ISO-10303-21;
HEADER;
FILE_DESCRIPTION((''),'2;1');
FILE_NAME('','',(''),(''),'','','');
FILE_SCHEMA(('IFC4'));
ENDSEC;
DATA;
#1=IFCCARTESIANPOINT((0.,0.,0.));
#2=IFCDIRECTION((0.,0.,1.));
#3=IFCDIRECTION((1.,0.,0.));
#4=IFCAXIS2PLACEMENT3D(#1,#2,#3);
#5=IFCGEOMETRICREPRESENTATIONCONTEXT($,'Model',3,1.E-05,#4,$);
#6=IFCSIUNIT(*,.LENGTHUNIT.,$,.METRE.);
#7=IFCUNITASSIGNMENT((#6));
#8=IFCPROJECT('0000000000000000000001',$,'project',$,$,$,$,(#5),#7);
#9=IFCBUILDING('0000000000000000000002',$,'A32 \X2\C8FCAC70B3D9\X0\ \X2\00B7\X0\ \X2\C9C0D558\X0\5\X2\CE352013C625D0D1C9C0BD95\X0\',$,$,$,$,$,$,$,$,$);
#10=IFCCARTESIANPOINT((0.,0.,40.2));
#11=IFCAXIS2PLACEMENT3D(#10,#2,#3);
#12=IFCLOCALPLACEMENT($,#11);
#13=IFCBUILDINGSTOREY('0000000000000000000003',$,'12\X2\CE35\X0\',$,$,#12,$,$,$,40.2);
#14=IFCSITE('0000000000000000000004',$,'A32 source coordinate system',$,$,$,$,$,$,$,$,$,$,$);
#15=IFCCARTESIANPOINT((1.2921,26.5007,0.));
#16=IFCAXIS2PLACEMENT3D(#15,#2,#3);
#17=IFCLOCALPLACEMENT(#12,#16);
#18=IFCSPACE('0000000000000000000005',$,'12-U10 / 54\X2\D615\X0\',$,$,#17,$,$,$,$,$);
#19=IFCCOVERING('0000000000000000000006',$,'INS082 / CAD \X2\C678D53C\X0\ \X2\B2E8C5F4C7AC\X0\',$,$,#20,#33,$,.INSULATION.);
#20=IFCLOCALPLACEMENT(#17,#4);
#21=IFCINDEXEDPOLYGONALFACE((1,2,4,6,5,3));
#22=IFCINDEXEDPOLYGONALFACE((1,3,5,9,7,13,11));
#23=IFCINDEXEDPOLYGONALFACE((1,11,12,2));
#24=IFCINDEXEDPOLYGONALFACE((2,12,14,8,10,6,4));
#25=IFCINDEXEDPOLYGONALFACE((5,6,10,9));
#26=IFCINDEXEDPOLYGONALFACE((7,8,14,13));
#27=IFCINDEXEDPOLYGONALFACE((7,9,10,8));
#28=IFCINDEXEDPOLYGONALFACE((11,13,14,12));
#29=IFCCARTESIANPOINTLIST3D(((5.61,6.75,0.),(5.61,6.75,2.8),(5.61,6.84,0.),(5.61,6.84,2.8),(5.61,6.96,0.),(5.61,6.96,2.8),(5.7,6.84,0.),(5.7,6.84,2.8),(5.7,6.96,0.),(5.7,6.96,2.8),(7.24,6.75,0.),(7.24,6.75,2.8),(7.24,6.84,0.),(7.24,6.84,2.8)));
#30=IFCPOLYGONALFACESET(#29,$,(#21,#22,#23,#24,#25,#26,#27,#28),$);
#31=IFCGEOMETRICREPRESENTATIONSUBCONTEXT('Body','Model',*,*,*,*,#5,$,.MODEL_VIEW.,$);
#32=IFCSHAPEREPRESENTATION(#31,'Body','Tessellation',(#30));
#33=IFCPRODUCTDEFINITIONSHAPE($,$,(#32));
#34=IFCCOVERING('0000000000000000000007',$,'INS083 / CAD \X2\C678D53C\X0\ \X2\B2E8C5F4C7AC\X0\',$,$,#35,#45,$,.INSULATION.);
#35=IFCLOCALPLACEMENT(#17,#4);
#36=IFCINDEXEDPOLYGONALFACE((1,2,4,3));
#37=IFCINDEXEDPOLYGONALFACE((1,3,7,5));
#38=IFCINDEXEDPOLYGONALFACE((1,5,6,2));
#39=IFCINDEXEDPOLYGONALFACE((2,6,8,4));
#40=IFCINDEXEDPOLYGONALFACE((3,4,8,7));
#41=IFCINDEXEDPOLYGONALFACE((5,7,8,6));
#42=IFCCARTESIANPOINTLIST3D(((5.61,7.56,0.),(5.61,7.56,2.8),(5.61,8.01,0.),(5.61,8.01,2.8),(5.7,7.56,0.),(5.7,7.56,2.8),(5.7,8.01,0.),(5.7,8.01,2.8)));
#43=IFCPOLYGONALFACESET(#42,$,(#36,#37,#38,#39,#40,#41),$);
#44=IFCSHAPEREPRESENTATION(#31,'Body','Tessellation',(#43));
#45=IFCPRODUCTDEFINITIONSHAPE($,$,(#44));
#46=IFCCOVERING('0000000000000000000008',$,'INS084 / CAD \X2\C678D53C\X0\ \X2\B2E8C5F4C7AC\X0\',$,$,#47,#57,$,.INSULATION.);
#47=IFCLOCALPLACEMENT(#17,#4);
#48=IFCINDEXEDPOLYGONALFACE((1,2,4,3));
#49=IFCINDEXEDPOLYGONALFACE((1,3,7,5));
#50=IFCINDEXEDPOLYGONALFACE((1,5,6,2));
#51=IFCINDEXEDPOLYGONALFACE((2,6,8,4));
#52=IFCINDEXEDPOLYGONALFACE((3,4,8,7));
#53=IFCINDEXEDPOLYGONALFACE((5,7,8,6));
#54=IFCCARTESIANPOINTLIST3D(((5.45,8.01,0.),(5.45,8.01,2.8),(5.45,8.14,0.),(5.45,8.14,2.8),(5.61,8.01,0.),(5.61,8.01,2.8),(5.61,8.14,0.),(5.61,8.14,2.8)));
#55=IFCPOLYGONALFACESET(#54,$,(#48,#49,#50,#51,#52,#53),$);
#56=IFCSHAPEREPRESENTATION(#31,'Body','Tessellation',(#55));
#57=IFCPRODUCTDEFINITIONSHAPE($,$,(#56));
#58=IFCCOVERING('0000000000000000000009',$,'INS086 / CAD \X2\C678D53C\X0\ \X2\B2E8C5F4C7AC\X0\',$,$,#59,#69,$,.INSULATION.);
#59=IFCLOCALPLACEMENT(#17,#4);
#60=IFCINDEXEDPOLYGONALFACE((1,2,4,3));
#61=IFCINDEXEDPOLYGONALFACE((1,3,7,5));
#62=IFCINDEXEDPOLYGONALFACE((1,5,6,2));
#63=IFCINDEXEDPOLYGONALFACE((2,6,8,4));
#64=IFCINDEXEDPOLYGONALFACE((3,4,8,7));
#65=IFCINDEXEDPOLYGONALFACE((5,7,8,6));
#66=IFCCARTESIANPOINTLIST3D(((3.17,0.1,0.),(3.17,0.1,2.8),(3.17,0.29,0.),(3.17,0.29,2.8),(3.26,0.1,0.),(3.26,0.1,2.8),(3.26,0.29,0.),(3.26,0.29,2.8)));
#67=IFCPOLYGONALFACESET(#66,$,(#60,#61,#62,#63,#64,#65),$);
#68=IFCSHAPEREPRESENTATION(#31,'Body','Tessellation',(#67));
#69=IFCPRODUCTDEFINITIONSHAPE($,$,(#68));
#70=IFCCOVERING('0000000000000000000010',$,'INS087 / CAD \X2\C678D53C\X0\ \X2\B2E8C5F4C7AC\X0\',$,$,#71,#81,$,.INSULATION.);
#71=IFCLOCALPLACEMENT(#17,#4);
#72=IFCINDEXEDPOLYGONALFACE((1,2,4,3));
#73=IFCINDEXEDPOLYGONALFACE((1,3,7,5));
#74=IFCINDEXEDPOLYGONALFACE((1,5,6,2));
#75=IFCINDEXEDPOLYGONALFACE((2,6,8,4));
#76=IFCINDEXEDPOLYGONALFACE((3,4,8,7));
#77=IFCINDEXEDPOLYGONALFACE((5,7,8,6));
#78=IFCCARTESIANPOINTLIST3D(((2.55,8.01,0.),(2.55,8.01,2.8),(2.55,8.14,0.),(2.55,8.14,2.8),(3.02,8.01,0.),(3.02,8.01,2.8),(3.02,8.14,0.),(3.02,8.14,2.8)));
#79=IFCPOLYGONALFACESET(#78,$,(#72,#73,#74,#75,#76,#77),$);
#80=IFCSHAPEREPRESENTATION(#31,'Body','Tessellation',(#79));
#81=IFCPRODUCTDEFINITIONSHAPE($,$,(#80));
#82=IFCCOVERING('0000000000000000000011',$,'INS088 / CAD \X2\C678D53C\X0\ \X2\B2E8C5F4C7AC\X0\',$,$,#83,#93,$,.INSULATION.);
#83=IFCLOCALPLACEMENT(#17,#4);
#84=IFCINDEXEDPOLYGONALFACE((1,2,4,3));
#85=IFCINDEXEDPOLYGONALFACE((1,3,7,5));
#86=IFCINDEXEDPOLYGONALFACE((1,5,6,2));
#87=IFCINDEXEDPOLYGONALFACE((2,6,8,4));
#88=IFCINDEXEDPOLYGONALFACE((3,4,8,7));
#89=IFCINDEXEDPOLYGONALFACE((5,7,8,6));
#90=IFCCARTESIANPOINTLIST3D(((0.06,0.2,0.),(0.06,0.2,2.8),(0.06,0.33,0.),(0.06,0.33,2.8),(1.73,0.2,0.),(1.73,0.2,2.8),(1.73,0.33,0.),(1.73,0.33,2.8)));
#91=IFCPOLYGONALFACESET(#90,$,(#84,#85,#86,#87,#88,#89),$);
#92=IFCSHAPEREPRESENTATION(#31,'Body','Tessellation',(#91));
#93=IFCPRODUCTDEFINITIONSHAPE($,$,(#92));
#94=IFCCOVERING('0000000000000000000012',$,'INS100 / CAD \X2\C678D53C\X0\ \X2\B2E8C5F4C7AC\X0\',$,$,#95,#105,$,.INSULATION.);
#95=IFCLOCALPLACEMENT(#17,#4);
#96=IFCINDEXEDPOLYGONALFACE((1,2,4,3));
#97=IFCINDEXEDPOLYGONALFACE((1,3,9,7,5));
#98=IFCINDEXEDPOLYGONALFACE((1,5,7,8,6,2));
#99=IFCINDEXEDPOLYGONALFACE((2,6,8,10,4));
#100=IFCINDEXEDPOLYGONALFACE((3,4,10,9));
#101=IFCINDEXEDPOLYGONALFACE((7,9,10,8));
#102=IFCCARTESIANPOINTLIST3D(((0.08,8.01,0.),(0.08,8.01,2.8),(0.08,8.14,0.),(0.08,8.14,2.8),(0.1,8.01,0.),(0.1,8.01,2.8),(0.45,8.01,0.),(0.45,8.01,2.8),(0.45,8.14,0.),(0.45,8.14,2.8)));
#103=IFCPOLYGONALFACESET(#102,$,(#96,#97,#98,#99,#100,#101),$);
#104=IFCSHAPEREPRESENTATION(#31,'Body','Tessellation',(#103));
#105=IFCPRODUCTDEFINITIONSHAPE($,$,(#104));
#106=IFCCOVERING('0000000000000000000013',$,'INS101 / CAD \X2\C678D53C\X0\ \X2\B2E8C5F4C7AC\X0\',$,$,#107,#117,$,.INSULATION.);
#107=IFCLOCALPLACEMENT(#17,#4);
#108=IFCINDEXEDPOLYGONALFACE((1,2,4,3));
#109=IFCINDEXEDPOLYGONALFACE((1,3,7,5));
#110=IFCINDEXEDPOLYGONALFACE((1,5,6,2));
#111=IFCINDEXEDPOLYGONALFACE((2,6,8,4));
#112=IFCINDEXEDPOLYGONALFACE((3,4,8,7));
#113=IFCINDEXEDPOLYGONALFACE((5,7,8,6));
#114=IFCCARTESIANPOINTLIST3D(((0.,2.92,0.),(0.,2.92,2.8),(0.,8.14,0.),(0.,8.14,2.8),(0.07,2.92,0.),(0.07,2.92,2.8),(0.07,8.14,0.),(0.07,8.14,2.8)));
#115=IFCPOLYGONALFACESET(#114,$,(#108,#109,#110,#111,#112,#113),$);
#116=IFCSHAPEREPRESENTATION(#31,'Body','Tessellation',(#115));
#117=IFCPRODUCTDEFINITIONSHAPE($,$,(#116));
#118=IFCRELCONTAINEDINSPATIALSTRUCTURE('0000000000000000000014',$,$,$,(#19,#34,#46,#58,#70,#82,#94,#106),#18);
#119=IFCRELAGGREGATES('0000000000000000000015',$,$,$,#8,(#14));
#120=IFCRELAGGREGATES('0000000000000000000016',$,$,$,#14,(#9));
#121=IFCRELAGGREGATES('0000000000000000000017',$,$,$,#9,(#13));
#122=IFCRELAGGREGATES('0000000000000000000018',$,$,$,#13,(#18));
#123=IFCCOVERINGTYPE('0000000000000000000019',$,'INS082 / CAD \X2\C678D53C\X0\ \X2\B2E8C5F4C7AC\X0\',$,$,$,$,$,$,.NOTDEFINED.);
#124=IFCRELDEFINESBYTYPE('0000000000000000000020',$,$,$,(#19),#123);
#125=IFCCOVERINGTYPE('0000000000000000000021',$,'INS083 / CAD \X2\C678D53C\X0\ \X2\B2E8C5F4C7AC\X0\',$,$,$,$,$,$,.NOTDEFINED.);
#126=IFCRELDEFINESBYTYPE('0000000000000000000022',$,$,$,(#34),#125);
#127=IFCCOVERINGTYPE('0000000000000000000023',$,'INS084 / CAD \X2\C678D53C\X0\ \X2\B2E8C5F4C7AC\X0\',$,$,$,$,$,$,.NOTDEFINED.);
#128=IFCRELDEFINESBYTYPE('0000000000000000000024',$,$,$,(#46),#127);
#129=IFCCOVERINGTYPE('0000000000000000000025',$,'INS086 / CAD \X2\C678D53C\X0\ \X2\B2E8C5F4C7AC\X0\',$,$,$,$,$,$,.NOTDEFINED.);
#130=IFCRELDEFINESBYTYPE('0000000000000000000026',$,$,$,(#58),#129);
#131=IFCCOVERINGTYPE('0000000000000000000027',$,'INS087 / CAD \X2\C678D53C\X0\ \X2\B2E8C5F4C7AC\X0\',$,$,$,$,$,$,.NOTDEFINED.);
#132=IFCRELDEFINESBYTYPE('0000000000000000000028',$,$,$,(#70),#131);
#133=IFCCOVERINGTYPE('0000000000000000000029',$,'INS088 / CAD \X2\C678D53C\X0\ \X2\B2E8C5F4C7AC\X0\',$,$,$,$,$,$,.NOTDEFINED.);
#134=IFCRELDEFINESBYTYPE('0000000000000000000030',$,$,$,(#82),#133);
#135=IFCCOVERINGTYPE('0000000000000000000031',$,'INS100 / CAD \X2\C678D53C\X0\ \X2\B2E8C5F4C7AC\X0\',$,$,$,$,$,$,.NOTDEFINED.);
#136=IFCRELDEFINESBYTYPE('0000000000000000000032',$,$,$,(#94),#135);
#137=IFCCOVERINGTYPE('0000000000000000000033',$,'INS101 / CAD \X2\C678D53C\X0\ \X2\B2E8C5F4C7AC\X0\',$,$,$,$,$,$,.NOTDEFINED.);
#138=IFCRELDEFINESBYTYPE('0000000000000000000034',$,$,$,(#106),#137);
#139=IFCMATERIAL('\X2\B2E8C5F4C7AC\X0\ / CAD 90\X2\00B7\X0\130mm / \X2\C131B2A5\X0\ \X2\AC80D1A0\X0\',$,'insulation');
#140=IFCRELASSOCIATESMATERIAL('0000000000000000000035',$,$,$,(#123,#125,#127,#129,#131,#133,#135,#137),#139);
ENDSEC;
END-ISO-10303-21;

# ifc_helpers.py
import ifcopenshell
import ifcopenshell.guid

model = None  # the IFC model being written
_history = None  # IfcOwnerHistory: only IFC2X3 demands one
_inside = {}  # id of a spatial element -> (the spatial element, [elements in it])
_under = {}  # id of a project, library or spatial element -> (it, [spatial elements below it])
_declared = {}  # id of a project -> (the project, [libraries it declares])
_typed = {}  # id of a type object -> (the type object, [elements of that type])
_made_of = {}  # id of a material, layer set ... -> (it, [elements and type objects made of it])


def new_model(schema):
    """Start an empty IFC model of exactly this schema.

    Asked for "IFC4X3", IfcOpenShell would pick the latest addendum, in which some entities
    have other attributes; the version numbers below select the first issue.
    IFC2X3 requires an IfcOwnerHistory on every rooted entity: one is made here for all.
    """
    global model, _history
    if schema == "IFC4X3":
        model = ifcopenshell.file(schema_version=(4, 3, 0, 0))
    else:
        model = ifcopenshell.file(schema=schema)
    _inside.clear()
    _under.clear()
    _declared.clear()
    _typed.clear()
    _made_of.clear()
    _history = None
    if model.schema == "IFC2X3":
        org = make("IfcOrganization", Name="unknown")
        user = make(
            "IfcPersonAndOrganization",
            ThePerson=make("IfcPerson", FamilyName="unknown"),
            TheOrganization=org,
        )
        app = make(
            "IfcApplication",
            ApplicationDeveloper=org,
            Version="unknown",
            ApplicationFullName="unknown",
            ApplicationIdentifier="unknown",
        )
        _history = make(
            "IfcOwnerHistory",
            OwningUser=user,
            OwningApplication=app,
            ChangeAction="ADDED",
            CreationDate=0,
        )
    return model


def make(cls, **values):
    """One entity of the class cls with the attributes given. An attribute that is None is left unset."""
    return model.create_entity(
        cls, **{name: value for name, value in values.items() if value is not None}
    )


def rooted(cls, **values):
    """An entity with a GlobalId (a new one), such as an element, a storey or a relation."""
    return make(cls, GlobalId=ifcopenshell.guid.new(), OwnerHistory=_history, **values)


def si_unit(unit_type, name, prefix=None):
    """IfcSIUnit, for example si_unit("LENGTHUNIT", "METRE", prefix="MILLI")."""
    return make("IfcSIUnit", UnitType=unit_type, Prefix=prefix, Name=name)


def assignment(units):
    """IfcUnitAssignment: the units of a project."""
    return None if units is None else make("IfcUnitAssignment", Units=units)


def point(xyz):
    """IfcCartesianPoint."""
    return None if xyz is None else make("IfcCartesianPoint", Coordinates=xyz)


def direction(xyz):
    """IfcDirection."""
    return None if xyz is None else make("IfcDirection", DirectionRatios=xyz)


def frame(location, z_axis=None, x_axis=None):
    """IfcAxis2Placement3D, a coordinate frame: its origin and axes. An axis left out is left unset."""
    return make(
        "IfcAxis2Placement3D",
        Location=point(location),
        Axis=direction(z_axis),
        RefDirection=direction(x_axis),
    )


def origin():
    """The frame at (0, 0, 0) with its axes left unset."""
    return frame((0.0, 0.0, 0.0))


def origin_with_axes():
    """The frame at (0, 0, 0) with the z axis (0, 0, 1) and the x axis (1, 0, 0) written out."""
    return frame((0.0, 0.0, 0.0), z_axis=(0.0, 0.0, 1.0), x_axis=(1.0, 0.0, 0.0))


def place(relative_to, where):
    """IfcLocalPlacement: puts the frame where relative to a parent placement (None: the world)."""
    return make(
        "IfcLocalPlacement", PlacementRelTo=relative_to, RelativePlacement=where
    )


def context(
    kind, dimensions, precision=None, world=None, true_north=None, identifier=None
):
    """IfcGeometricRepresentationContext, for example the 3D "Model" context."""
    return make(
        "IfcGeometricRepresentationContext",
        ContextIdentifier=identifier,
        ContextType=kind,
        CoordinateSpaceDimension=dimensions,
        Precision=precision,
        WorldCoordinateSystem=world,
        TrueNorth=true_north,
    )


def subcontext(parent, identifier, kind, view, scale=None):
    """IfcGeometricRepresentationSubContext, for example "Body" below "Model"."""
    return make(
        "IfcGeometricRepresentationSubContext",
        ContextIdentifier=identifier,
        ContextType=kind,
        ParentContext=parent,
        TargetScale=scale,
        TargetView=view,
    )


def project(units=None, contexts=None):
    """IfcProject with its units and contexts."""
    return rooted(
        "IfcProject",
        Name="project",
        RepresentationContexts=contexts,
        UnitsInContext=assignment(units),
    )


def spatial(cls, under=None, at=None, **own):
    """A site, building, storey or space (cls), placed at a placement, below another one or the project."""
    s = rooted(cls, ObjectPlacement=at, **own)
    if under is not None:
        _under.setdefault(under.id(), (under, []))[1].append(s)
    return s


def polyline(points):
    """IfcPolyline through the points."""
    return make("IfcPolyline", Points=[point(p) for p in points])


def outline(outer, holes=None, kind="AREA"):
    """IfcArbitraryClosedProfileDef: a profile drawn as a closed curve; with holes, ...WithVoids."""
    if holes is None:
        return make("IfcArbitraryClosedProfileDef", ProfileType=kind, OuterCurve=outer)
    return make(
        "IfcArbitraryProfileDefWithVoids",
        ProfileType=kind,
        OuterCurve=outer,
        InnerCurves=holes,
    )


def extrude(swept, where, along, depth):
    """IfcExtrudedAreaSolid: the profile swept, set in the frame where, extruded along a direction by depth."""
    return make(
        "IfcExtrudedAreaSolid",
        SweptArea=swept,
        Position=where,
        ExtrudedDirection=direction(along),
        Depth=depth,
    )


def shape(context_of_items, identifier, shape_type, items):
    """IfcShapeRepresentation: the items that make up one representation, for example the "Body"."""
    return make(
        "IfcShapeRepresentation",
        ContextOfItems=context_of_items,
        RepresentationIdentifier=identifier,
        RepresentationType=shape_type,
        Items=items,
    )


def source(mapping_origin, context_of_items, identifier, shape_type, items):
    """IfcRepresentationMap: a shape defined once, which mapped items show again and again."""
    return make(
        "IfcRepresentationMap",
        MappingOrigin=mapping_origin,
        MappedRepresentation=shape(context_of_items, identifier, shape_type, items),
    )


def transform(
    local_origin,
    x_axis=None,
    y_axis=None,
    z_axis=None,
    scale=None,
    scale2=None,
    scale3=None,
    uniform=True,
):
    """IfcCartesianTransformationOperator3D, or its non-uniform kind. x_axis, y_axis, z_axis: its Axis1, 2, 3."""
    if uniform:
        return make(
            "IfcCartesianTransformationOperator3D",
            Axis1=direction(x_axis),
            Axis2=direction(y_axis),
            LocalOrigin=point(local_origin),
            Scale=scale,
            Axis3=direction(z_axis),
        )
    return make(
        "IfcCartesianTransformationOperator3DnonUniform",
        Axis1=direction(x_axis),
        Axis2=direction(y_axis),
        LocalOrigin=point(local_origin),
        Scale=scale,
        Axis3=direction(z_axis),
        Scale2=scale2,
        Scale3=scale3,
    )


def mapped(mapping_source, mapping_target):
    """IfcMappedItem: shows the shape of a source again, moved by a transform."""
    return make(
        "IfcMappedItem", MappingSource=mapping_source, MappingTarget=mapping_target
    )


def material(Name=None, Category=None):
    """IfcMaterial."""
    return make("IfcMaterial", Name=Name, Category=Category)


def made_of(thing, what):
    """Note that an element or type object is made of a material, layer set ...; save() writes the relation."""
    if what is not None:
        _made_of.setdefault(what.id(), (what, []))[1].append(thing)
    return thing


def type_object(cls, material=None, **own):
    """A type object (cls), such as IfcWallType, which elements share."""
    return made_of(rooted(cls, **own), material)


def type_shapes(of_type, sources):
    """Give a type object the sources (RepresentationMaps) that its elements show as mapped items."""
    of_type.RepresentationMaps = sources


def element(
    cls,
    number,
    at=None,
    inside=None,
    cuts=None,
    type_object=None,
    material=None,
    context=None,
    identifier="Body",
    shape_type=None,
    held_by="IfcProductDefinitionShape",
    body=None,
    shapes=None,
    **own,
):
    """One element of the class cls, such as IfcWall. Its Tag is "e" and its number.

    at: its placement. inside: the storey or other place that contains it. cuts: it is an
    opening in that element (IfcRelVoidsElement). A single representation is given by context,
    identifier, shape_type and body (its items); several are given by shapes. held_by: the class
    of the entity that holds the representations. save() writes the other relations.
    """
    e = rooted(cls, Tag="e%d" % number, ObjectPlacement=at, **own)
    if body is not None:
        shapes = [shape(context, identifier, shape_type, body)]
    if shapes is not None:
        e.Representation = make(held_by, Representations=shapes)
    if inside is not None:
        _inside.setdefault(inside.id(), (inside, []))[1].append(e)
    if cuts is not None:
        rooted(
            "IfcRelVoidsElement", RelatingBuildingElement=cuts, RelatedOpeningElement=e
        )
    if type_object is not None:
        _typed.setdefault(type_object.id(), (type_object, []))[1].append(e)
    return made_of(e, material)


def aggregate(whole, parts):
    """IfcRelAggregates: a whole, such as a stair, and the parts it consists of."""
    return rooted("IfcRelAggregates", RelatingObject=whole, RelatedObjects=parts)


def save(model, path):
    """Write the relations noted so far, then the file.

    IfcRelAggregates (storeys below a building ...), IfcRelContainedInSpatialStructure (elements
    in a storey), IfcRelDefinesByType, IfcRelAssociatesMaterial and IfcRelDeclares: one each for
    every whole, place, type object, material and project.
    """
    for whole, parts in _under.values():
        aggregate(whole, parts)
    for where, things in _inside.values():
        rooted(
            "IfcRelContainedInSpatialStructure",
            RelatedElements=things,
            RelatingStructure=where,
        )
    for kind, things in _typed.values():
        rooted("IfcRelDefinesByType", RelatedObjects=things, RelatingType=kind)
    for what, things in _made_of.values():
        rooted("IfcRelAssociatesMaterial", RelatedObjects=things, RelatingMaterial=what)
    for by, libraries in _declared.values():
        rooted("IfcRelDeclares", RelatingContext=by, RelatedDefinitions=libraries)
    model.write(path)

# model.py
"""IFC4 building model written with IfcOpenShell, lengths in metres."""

from ifc_helpers import new_model, si_unit, frame, origin, origin_with_axes, place, context, subcontext, project, spatial, polyline, outline, extrude, source, transform, mapped, material, type_object, type_shapes, element, save


model = new_model("IFC4")

# Units and contexts
model_context = context("Model", 3, precision=1e-05, world=origin_with_axes())
body_context = subcontext(model_context, "Body", "Model", "MODEL_VIEW")
ifc_project = project(units=[si_unit("LENGTHUNIT", "METRE")], contexts=[model_context])

# Site, building, storey, space
storey_placement = place(None, frame((0.0, 0.0, 40.2), z_axis=(0.0, 0.0, 1.0), x_axis=(1.0, 0.0, 0.0)))
space_placement = place(storey_placement, frame((1.2921, 26.5007, 0.0), z_axis=(0.0, 0.0, 1.0), x_axis=(1.0, 0.0, 0.0)))
site = spatial("IfcSite", under=ifc_project, Name="A32 source coordinate system")
building = spatial("IfcBuilding", under=site, Name="A32 주거동 · 지하5층–옥탑지붕")
storey = spatial("IfcBuildingStorey", under=building, at=storey_placement, Name="12층", Elevation=40.2)
space = spatial("IfcSpace", under=storey, at=space_placement, Name="12-U10 / 54형")

# Coverings
ifc_material = material(Name="단열재 / CAD 90·130mm / 성능 검토", Category="insulation")
covering_type_1 = type_object("IfcCoveringType", Name="INS082 / CAD 외피 단열재", PredefinedType="NOTDEFINED", material=ifc_material)
shared_shape_1 = source(origin(), body_context, "Body", "SweptSolid", [
    extrude(outline(polyline([(5.61, 6.84), (5.61, 6.96), (5.7, 6.96), (5.7, 6.84), (7.24, 6.84), (7.24, 6.75), (5.61, 6.75), (5.61, 6.84)])), origin(), (0.0, 0.0, 1.0), 2.8),
])
type_shapes(covering_type_1, [shared_shape_1])
covering_1_placement = place(space_placement, origin_with_axes())
element("IfcCovering", 1, at=covering_1_placement, inside=space, type_object=covering_type_1, Name="INS082 / CAD 외피 단열재", PredefinedType="INSULATION", context=body_context, shape_type="MappedRepresentation", body=[
    mapped(shared_shape_1, transform((0.0, 0.0, 0.0), scale=1.0)),
])
covering_type_2 = type_object("IfcCoveringType", Name="INS083 / CAD 외피 단열재", PredefinedType="NOTDEFINED", material=ifc_material)
shared_shape_2 = source(origin(), body_context, "Body", "SweptSolid", [
    extrude(outline(polyline([(5.61, 8.01), (5.7, 8.01), (5.7, 7.56), (5.61, 7.56), (5.61, 8.01)])), origin(), (0.0, 0.0, 1.0), 2.8),
])
type_shapes(covering_type_2, [shared_shape_2])
covering_2_placement = place(space_placement, origin_with_axes())
element("IfcCovering", 2, at=covering_2_placement, inside=space, type_object=covering_type_2, Name="INS083 / CAD 외피 단열재", PredefinedType="INSULATION", context=body_context, shape_type="MappedRepresentation", body=[
    mapped(shared_shape_2, transform((0.0, 0.0, 0.0), scale=1.0)),
])
covering_type_3 = type_object("IfcCoveringType", Name="INS084 / CAD 외피 단열재", PredefinedType="NOTDEFINED", material=ifc_material)
shared_shape_3 = source(origin(), body_context, "Body", "SweptSolid", [
    extrude(outline(polyline([(5.45, 8.01), (5.45, 8.14), (5.61, 8.14), (5.61, 8.01), (5.45, 8.01)])), origin(), (0.0, 0.0, 1.0), 2.8),
])
type_shapes(covering_type_3, [shared_shape_3])
covering_3_placement = place(space_placement, origin_with_axes())
element("IfcCovering", 3, at=covering_3_placement, inside=space, type_object=covering_type_3, Name="INS084 / CAD 외피 단열재", PredefinedType="INSULATION", context=body_context, shape_type="MappedRepresentation", body=[
    mapped(shared_shape_3, transform((0.0, 0.0, 0.0), scale=1.0)),
])
covering_type_4 = type_object("IfcCoveringType", Name="INS086 / CAD 외피 단열재", PredefinedType="NOTDEFINED", material=ifc_material)
shared_shape_4 = source(origin(), body_context, "Body", "SweptSolid", [
    extrude(outline(polyline([(3.17, 0.1), (3.17, 0.29), (3.26, 0.29), (3.26, 0.1), (3.17, 0.1)])), origin(), (0.0, 0.0, 1.0), 2.8),
])
type_shapes(covering_type_4, [shared_shape_4])
covering_4_placement = place(space_placement, origin_with_axes())
element("IfcCovering", 4, at=covering_4_placement, inside=space, type_object=covering_type_4, Name="INS086 / CAD 외피 단열재", PredefinedType="INSULATION", context=body_context, shape_type="MappedRepresentation", body=[
    mapped(shared_shape_4, transform((0.0, 0.0, 0.0), scale=1.0)),
])
covering_type_5 = type_object("IfcCoveringType", Name="INS087 / CAD 외피 단열재", PredefinedType="NOTDEFINED", material=ifc_material)
shared_shape_5 = source(origin(), body_context, "Body", "SweptSolid", [
    extrude(outline(polyline([(2.55, 8.14), (3.02, 8.14), (3.02, 8.01), (2.55, 8.01), (2.55, 8.14)])), origin(), (0.0, 0.0, 1.0), 2.8),
])
type_shapes(covering_type_5, [shared_shape_5])
covering_5_placement = place(space_placement, origin_with_axes())
element("IfcCovering", 5, at=covering_5_placement, inside=space, type_object=covering_type_5, Name="INS087 / CAD 외피 단열재", PredefinedType="INSULATION", context=body_context, shape_type="MappedRepresentation", body=[
    mapped(shared_shape_5, transform((0.0, 0.0, 0.0), scale=1.0)),
])
covering_type_6 = type_object("IfcCoveringType", Name="INS088 / CAD 외피 단열재", PredefinedType="NOTDEFINED", material=ifc_material)
shared_shape_6 = source(origin(), body_context, "Body", "SweptSolid", [
    extrude(outline(polyline([(0.06, 0.33), (1.73, 0.33), (1.73, 0.2), (0.06, 0.2), (0.06, 0.33)])), origin(), (0.0, 0.0, 1.0), 2.8),
])
type_shapes(covering_type_6, [shared_shape_6])
covering_6_placement = place(space_placement, origin_with_axes())
element("IfcCovering", 6, at=covering_6_placement, inside=space, type_object=covering_type_6, Name="INS088 / CAD 외피 단열재", PredefinedType="INSULATION", context=body_context, shape_type="MappedRepresentation", body=[
    mapped(shared_shape_6, transform((0.0, 0.0, 0.0), scale=1.0)),
])
covering_type_7 = type_object("IfcCoveringType", Name="INS100 / CAD 외피 단열재", PredefinedType="NOTDEFINED", material=ifc_material)
shared_shape_7 = source(origin(), body_context, "Body", "SweptSolid", [
    extrude(outline(polyline([(0.08, 8.01), (0.08, 8.14), (0.45, 8.14), (0.45, 8.01), (0.1, 8.01), (0.08, 8.01)])), origin(), (0.0, 0.0, 1.0), 2.8),
])
type_shapes(covering_type_7, [shared_shape_7])
covering_7_placement = place(space_placement, origin_with_axes())
element("IfcCovering", 7, at=covering_7_placement, inside=space, type_object=covering_type_7, Name="INS100 / CAD 외피 단열재", PredefinedType="INSULATION", context=body_context, shape_type="MappedRepresentation", body=[
    mapped(shared_shape_7, transform((0.0, 0.0, 0.0), scale=1.0)),
])
covering_type_8 = type_object("IfcCoveringType", Name="INS101 / CAD 외피 단열재", PredefinedType="NOTDEFINED", material=ifc_material)
shared_shape_8 = source(origin(), body_context, "Body", "SweptSolid", [
    extrude(outline(polyline([(0.0, 2.92), (0.0, 8.14), (0.07, 8.14), (0.07, 2.92), (0.0, 2.92)])), origin(), (0.0, 0.0, 1.0), 2.8),
])
type_shapes(covering_type_8, [shared_shape_8])
covering_8_placement = place(space_placement, origin_with_axes())
element("IfcCovering", 8, at=covering_8_placement, inside=space, type_object=covering_type_8, Name="INS101 / CAD 외피 단열재", PredefinedType="INSULATION", context=body_context, shape_type="MappedRepresentation", body=[
    mapped(shared_shape_8, transform((0.0, 0.0, 0.0), scale=1.0)),
])

save(model, "model.ifc")
